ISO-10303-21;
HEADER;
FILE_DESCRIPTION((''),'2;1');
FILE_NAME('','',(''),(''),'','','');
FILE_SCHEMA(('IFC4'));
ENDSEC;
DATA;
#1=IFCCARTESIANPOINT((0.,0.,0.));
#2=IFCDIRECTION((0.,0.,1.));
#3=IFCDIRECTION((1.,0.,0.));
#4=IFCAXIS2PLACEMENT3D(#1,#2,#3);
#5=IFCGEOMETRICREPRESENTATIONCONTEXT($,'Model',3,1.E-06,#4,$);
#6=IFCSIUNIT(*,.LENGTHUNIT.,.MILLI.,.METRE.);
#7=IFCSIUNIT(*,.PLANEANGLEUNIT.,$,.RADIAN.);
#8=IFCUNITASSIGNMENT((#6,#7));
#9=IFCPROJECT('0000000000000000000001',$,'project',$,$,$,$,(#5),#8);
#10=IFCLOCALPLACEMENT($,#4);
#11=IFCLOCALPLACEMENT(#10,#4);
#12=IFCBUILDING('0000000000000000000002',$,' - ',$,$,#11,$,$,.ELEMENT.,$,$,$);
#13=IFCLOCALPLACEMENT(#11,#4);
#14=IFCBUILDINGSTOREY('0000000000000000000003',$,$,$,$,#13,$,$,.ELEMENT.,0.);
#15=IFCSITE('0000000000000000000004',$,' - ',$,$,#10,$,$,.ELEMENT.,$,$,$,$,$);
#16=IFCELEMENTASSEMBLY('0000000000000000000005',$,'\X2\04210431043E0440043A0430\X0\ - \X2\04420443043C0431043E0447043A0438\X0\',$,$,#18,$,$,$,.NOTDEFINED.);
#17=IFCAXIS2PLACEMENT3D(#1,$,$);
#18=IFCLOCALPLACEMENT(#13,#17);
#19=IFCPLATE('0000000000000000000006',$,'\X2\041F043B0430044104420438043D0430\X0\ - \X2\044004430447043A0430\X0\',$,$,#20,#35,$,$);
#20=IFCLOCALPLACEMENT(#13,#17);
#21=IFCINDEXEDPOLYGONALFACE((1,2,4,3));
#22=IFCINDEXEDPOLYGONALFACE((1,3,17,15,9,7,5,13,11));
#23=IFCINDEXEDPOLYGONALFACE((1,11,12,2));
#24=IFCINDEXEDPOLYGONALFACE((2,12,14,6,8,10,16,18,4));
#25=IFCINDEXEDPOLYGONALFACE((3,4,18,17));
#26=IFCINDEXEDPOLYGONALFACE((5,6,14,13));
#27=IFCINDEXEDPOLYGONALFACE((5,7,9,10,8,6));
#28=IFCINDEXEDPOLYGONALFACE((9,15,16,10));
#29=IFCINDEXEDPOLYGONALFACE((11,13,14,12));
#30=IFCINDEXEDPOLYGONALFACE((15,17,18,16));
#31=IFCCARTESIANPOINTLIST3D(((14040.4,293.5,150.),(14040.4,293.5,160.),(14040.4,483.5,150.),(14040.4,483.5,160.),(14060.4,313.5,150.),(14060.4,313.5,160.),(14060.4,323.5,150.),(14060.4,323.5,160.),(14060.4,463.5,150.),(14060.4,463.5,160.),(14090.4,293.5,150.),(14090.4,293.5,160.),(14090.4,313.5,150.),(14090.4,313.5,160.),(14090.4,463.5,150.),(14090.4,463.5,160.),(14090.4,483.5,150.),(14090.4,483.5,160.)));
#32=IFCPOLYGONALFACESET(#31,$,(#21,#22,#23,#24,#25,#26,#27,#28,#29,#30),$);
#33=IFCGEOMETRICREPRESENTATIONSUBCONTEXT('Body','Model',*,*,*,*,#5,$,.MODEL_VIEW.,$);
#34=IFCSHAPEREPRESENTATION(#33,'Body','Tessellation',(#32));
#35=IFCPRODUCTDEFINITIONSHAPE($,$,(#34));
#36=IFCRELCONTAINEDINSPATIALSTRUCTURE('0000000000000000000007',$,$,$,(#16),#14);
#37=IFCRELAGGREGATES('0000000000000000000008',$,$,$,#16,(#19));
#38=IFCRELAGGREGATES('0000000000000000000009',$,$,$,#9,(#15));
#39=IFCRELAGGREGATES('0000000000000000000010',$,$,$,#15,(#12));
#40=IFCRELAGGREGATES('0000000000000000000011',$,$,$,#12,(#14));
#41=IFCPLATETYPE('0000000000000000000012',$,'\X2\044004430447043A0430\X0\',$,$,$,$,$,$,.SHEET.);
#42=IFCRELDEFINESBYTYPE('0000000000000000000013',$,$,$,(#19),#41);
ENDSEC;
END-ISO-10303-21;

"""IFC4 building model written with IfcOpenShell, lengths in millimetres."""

from ifc_helpers import new_model, si_unit, frame, origin_with_axes, place, context, subcontext, project, spatial, line, indexed_curve, outline, extrude, source, transform, mapped, type_object, element, aggregate, save


model = new_model("IFC4")

# Units and contexts
model_context = context("Model", 3, precision=1e-06, world=origin_with_axes())
body_context = subcontext(model_context, "Body", "Model", "MODEL_VIEW")
ifc_project = project(units=[si_unit("LENGTHUNIT", "METRE", prefix="MILLI"), si_unit("PLANEANGLEUNIT", "RADIAN")], contexts=[model_context])

# Site, building, storey
site_placement = place(None, origin_with_axes())
site = spatial("IfcSite", under=ifc_project, at=site_placement, Name=" - ", CompositionType="ELEMENT")
building_placement = place(site_placement, origin_with_axes())
building = spatial("IfcBuilding", under=site, at=building_placement, Name=" - ", CompositionType="ELEMENT")
storey_placement = place(building_placement, origin_with_axes())
storey = spatial("IfcBuildingStorey", under=building, at=storey_placement, CompositionType="ELEMENT", Elevation=0.0)

# Shared definitions
plate_type = type_object("IfcPlateType", Name="ручка", PredefinedType="SHEET")
shared_shape = source(origin_with_axes(), body_context, "Body", "SweptSolid", [
    extrude(outline(indexed_curve([(-95.0, -25.0), (-75.0, -25.0), (-75.0, 5.0), (-65.0, 5.0), (75.0, 5.0), (75.0, -25.0), (95.0, -25.0), (95.0, 25.0), (-95.0, 25.0)], segments=[line(1, 2), line(2, 3), line(3, 4), line(4, 5), line(5, 6), line(6, 7), line(7, 8), line(8, 9), line(9, 1)])), origin_with_axes(), (0.0, 0.0, 1.0), 10.0),
])

# Element assembly, plate
assembly_1_placement = place(storey_placement, frame((14090.4, 588.5, 0.0), z_axis=(0.0, 0.0, 1.0), x_axis=(0.0, -1.0, 0.0)))
assembly_1 = element("IfcElementAssembly", 1, at=assembly_1_placement, inside=storey, Name="Сборка - тумбочки", PredefinedType="NOTDEFINED")
plate_1_placement = place(assembly_1_placement, frame((200.0, -25.0, 150.0), z_axis=(0.0, 0.0, 1.0), x_axis=(-1.0, 0.0, 0.0)))
plate_1 = element("IfcPlate", 2, at=plate_1_placement, type_object=plate_type, Name="Пластина - ручка", context=body_context, shape_type="MappedRepresentation", body=[
    mapped(shared_shape, transform((0.0, 0.0, 0.0), x_axis=(1.0, 0.0, 0.0), y_axis=(0.0, 1.0, 0.0), z_axis=(0.0, 0.0, 1.0), scale=1.0)),
])
aggregate(assembly_1, [plate_1])

save(model, "model.ifc")
